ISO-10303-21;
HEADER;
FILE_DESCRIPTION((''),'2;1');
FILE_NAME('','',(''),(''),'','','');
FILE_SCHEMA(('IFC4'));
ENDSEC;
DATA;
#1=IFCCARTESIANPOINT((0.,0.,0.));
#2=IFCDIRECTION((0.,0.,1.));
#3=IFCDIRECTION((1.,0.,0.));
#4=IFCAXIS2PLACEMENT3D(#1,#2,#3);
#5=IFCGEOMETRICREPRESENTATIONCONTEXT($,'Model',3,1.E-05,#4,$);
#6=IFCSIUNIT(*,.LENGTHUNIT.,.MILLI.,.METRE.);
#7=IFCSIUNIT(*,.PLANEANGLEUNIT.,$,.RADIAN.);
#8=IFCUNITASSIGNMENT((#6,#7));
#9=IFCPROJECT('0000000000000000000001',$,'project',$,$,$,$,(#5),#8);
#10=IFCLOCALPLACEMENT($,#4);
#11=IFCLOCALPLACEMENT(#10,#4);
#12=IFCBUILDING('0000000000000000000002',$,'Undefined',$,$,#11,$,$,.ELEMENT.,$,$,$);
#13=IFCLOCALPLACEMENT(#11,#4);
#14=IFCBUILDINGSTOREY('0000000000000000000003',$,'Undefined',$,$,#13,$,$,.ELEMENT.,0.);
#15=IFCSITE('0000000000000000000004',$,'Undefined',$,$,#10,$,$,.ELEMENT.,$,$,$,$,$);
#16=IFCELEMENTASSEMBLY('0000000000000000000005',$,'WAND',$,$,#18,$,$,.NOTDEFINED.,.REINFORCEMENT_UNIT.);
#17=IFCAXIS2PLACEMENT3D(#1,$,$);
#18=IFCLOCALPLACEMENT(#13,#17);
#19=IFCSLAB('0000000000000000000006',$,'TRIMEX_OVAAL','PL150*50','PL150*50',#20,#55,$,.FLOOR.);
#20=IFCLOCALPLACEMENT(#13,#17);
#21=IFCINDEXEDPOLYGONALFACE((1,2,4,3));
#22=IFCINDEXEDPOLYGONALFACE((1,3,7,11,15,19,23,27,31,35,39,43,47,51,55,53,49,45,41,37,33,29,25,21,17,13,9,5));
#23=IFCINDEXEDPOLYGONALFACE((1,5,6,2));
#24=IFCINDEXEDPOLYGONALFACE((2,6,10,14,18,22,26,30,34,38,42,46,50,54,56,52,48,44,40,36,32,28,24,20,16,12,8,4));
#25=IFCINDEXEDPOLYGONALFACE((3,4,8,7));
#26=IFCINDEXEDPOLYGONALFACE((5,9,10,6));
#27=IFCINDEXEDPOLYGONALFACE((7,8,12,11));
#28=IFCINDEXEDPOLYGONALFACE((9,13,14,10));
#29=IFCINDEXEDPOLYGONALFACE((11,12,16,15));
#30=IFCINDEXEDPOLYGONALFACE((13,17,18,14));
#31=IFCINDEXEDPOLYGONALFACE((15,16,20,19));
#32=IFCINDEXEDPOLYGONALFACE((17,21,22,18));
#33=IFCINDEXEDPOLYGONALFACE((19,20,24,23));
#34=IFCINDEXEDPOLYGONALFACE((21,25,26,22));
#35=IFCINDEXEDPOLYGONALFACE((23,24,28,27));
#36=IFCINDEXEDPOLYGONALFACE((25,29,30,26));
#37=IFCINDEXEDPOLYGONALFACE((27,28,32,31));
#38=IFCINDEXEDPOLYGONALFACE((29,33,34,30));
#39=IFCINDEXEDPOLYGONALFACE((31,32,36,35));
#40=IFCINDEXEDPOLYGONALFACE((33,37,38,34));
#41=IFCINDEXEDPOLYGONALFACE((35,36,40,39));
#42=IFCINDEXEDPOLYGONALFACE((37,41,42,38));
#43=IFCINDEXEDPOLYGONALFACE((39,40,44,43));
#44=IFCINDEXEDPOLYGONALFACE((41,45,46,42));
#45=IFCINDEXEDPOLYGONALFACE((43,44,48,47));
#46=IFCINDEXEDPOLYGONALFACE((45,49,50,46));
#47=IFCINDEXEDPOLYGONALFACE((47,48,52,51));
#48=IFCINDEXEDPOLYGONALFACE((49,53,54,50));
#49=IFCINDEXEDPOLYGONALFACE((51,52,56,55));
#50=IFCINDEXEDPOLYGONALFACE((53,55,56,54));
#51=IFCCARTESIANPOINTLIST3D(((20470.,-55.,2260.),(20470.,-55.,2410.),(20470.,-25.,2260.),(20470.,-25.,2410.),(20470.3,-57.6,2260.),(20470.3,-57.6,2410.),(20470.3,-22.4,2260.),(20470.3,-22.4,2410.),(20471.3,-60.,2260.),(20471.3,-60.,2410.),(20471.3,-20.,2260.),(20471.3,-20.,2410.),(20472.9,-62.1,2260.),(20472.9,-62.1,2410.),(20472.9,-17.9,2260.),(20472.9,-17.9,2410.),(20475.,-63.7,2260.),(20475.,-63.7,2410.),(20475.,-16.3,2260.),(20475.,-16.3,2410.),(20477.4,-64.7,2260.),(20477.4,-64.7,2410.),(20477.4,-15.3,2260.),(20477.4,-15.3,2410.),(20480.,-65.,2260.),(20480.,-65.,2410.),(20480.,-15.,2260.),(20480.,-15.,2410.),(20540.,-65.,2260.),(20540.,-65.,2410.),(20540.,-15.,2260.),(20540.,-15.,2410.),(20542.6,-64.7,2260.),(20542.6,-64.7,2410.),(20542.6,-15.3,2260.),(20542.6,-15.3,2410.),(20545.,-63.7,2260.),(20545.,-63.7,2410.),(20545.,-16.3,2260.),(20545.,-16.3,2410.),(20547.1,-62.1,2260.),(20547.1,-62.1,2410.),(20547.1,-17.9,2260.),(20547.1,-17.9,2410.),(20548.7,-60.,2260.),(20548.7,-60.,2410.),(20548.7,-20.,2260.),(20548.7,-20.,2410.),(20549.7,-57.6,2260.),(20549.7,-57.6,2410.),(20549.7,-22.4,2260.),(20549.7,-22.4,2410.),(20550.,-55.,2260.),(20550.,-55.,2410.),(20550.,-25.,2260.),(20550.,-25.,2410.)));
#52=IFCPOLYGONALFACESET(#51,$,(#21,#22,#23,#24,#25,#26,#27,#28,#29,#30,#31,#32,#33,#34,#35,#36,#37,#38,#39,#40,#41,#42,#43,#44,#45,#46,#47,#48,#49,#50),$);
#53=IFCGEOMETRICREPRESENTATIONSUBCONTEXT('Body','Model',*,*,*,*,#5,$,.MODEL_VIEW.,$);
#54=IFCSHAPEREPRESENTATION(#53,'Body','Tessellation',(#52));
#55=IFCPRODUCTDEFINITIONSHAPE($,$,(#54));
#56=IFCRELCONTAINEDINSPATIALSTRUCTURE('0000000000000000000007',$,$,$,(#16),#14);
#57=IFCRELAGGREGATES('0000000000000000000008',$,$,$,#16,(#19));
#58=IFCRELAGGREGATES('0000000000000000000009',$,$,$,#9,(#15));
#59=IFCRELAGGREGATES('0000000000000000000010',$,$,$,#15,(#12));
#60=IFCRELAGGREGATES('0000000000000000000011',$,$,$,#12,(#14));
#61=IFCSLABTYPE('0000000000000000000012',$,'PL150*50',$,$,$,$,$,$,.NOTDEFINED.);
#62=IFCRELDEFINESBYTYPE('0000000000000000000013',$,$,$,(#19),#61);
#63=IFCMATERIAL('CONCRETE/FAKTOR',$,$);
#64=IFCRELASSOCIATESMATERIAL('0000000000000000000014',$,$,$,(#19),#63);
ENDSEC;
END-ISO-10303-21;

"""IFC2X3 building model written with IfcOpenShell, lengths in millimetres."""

from ifc_helpers import new_model, si_unit, frame, frame_2d, origin_with_axes, place, context, subcontext, project, spatial, polyline, circle_curve, parameter, trimmed, segment, composite_curve, outline, extrude, material, type_object, element, aggregate, save


model = new_model("IFC2X3")

# Units and contexts
model_context = context("Model", 3, precision=1e-05, world=origin_with_axes())
body_context = subcontext(model_context, "Body", "Model", "MODEL_VIEW")
ifc_project = project(units=[si_unit("LENGTHUNIT", "METRE", prefix="MILLI"), si_unit("PLANEANGLEUNIT", "RADIAN")], contexts=[model_context])

# Site, building, storey
site_placement = place(None, origin_with_axes())
site = spatial("IfcSite", under=ifc_project, at=site_placement, Name="Undefined", CompositionType="ELEMENT")
building_placement = place(site_placement, origin_with_axes())
building = spatial("IfcBuilding", under=site, at=building_placement, Name="Undefined", CompositionType="ELEMENT")
storey_placement = place(building_placement, origin_with_axes())
storey = spatial("IfcBuildingStorey", under=building, at=storey_placement, Name="Undefined", CompositionType="ELEMENT", Elevation=0.0)

# Element assembly
ifc_material_1 = material(Name="CONCRETE/FAKTOR")
assembly_1_placement = place(storey_placement, origin_with_axes())
assembly_1 = element("IfcElementAssembly", 1, at=assembly_1_placement, inside=storey, Name="WAND", AssemblyPlace="NOTDEFINED", PredefinedType="REINFORCEMENT_UNIT")

# Slab
slab_type = type_object("IfcSlabType", Name="PL150*50", PredefinedType="NOTDEFINED")
slab_placement = place(assembly_1_placement, frame((20470.0, -15.0, 2335.0), z_axis=(0.0, 0.0, 1.0), x_axis=(0.0, -1.0, 0.0)))
slab = element("IfcSlab", 2, at=slab_placement, type_object=slab_type, material=ifc_material_1, Name="TRIMEX_OVAAL", Description="PL150*50", ObjectType="PL150*50", PredefinedType="FLOOR", context=body_context, shape_type="SweptSolid", body=[
    extrude(outline(composite_curve([segment(trimmed(circle_curve(frame_2d((10.0, 10.0), x_axis=(-1.0, 0.0)), 10.0), [parameter(0.0)], [parameter(1.570796)], True, "PARAMETER"), True, "CONTINUOUS"), segment(polyline([(10.0, 0.0), (40.0, 0.0)]), True, "CONTINUOUS"), segment(trimmed(circle_curve(frame_2d((40.0, 10.0), x_axis=(0.0, -1.0)), 10.0), [parameter(0.0)], [parameter(1.570796)], True, "PARAMETER"), True, "CONTINUOUS"), segment(polyline([(50.0, 10.0), (50.0, 70.0)]), True, "CONTINUOUS"), segment(trimmed(circle_curve(frame_2d((40.0, 70.0), x_axis=(1.0, 0.0)), 10.0), [parameter(0.0)], [parameter(1.570796)], True, "PARAMETER"), True, "CONTINUOUS"), segment(polyline([(40.0, 80.0), (10.0, 80.0)]), True, "CONTINUOUS"), segment(trimmed(circle_curve(frame_2d((10.0, 70.0), x_axis=(0.0, 1.0)), 10.0), [parameter(0.0)], [parameter(1.570796)], True, "PARAMETER"), True, "CONTINUOUS"), segment(polyline([(0.0, 70.0), (0.0, 10.0)]), True, "CONTINUOUS")], self_intersect=True)), frame((0.0, 0.0, -75.0), z_axis=(0.0, 0.0, 1.0), x_axis=(1.0, 0.0, 0.0)), (0.0, 0.0, 1.0), 150.0),
])
aggregate(assembly_1, [slab])

save(model, "model.ifc")
